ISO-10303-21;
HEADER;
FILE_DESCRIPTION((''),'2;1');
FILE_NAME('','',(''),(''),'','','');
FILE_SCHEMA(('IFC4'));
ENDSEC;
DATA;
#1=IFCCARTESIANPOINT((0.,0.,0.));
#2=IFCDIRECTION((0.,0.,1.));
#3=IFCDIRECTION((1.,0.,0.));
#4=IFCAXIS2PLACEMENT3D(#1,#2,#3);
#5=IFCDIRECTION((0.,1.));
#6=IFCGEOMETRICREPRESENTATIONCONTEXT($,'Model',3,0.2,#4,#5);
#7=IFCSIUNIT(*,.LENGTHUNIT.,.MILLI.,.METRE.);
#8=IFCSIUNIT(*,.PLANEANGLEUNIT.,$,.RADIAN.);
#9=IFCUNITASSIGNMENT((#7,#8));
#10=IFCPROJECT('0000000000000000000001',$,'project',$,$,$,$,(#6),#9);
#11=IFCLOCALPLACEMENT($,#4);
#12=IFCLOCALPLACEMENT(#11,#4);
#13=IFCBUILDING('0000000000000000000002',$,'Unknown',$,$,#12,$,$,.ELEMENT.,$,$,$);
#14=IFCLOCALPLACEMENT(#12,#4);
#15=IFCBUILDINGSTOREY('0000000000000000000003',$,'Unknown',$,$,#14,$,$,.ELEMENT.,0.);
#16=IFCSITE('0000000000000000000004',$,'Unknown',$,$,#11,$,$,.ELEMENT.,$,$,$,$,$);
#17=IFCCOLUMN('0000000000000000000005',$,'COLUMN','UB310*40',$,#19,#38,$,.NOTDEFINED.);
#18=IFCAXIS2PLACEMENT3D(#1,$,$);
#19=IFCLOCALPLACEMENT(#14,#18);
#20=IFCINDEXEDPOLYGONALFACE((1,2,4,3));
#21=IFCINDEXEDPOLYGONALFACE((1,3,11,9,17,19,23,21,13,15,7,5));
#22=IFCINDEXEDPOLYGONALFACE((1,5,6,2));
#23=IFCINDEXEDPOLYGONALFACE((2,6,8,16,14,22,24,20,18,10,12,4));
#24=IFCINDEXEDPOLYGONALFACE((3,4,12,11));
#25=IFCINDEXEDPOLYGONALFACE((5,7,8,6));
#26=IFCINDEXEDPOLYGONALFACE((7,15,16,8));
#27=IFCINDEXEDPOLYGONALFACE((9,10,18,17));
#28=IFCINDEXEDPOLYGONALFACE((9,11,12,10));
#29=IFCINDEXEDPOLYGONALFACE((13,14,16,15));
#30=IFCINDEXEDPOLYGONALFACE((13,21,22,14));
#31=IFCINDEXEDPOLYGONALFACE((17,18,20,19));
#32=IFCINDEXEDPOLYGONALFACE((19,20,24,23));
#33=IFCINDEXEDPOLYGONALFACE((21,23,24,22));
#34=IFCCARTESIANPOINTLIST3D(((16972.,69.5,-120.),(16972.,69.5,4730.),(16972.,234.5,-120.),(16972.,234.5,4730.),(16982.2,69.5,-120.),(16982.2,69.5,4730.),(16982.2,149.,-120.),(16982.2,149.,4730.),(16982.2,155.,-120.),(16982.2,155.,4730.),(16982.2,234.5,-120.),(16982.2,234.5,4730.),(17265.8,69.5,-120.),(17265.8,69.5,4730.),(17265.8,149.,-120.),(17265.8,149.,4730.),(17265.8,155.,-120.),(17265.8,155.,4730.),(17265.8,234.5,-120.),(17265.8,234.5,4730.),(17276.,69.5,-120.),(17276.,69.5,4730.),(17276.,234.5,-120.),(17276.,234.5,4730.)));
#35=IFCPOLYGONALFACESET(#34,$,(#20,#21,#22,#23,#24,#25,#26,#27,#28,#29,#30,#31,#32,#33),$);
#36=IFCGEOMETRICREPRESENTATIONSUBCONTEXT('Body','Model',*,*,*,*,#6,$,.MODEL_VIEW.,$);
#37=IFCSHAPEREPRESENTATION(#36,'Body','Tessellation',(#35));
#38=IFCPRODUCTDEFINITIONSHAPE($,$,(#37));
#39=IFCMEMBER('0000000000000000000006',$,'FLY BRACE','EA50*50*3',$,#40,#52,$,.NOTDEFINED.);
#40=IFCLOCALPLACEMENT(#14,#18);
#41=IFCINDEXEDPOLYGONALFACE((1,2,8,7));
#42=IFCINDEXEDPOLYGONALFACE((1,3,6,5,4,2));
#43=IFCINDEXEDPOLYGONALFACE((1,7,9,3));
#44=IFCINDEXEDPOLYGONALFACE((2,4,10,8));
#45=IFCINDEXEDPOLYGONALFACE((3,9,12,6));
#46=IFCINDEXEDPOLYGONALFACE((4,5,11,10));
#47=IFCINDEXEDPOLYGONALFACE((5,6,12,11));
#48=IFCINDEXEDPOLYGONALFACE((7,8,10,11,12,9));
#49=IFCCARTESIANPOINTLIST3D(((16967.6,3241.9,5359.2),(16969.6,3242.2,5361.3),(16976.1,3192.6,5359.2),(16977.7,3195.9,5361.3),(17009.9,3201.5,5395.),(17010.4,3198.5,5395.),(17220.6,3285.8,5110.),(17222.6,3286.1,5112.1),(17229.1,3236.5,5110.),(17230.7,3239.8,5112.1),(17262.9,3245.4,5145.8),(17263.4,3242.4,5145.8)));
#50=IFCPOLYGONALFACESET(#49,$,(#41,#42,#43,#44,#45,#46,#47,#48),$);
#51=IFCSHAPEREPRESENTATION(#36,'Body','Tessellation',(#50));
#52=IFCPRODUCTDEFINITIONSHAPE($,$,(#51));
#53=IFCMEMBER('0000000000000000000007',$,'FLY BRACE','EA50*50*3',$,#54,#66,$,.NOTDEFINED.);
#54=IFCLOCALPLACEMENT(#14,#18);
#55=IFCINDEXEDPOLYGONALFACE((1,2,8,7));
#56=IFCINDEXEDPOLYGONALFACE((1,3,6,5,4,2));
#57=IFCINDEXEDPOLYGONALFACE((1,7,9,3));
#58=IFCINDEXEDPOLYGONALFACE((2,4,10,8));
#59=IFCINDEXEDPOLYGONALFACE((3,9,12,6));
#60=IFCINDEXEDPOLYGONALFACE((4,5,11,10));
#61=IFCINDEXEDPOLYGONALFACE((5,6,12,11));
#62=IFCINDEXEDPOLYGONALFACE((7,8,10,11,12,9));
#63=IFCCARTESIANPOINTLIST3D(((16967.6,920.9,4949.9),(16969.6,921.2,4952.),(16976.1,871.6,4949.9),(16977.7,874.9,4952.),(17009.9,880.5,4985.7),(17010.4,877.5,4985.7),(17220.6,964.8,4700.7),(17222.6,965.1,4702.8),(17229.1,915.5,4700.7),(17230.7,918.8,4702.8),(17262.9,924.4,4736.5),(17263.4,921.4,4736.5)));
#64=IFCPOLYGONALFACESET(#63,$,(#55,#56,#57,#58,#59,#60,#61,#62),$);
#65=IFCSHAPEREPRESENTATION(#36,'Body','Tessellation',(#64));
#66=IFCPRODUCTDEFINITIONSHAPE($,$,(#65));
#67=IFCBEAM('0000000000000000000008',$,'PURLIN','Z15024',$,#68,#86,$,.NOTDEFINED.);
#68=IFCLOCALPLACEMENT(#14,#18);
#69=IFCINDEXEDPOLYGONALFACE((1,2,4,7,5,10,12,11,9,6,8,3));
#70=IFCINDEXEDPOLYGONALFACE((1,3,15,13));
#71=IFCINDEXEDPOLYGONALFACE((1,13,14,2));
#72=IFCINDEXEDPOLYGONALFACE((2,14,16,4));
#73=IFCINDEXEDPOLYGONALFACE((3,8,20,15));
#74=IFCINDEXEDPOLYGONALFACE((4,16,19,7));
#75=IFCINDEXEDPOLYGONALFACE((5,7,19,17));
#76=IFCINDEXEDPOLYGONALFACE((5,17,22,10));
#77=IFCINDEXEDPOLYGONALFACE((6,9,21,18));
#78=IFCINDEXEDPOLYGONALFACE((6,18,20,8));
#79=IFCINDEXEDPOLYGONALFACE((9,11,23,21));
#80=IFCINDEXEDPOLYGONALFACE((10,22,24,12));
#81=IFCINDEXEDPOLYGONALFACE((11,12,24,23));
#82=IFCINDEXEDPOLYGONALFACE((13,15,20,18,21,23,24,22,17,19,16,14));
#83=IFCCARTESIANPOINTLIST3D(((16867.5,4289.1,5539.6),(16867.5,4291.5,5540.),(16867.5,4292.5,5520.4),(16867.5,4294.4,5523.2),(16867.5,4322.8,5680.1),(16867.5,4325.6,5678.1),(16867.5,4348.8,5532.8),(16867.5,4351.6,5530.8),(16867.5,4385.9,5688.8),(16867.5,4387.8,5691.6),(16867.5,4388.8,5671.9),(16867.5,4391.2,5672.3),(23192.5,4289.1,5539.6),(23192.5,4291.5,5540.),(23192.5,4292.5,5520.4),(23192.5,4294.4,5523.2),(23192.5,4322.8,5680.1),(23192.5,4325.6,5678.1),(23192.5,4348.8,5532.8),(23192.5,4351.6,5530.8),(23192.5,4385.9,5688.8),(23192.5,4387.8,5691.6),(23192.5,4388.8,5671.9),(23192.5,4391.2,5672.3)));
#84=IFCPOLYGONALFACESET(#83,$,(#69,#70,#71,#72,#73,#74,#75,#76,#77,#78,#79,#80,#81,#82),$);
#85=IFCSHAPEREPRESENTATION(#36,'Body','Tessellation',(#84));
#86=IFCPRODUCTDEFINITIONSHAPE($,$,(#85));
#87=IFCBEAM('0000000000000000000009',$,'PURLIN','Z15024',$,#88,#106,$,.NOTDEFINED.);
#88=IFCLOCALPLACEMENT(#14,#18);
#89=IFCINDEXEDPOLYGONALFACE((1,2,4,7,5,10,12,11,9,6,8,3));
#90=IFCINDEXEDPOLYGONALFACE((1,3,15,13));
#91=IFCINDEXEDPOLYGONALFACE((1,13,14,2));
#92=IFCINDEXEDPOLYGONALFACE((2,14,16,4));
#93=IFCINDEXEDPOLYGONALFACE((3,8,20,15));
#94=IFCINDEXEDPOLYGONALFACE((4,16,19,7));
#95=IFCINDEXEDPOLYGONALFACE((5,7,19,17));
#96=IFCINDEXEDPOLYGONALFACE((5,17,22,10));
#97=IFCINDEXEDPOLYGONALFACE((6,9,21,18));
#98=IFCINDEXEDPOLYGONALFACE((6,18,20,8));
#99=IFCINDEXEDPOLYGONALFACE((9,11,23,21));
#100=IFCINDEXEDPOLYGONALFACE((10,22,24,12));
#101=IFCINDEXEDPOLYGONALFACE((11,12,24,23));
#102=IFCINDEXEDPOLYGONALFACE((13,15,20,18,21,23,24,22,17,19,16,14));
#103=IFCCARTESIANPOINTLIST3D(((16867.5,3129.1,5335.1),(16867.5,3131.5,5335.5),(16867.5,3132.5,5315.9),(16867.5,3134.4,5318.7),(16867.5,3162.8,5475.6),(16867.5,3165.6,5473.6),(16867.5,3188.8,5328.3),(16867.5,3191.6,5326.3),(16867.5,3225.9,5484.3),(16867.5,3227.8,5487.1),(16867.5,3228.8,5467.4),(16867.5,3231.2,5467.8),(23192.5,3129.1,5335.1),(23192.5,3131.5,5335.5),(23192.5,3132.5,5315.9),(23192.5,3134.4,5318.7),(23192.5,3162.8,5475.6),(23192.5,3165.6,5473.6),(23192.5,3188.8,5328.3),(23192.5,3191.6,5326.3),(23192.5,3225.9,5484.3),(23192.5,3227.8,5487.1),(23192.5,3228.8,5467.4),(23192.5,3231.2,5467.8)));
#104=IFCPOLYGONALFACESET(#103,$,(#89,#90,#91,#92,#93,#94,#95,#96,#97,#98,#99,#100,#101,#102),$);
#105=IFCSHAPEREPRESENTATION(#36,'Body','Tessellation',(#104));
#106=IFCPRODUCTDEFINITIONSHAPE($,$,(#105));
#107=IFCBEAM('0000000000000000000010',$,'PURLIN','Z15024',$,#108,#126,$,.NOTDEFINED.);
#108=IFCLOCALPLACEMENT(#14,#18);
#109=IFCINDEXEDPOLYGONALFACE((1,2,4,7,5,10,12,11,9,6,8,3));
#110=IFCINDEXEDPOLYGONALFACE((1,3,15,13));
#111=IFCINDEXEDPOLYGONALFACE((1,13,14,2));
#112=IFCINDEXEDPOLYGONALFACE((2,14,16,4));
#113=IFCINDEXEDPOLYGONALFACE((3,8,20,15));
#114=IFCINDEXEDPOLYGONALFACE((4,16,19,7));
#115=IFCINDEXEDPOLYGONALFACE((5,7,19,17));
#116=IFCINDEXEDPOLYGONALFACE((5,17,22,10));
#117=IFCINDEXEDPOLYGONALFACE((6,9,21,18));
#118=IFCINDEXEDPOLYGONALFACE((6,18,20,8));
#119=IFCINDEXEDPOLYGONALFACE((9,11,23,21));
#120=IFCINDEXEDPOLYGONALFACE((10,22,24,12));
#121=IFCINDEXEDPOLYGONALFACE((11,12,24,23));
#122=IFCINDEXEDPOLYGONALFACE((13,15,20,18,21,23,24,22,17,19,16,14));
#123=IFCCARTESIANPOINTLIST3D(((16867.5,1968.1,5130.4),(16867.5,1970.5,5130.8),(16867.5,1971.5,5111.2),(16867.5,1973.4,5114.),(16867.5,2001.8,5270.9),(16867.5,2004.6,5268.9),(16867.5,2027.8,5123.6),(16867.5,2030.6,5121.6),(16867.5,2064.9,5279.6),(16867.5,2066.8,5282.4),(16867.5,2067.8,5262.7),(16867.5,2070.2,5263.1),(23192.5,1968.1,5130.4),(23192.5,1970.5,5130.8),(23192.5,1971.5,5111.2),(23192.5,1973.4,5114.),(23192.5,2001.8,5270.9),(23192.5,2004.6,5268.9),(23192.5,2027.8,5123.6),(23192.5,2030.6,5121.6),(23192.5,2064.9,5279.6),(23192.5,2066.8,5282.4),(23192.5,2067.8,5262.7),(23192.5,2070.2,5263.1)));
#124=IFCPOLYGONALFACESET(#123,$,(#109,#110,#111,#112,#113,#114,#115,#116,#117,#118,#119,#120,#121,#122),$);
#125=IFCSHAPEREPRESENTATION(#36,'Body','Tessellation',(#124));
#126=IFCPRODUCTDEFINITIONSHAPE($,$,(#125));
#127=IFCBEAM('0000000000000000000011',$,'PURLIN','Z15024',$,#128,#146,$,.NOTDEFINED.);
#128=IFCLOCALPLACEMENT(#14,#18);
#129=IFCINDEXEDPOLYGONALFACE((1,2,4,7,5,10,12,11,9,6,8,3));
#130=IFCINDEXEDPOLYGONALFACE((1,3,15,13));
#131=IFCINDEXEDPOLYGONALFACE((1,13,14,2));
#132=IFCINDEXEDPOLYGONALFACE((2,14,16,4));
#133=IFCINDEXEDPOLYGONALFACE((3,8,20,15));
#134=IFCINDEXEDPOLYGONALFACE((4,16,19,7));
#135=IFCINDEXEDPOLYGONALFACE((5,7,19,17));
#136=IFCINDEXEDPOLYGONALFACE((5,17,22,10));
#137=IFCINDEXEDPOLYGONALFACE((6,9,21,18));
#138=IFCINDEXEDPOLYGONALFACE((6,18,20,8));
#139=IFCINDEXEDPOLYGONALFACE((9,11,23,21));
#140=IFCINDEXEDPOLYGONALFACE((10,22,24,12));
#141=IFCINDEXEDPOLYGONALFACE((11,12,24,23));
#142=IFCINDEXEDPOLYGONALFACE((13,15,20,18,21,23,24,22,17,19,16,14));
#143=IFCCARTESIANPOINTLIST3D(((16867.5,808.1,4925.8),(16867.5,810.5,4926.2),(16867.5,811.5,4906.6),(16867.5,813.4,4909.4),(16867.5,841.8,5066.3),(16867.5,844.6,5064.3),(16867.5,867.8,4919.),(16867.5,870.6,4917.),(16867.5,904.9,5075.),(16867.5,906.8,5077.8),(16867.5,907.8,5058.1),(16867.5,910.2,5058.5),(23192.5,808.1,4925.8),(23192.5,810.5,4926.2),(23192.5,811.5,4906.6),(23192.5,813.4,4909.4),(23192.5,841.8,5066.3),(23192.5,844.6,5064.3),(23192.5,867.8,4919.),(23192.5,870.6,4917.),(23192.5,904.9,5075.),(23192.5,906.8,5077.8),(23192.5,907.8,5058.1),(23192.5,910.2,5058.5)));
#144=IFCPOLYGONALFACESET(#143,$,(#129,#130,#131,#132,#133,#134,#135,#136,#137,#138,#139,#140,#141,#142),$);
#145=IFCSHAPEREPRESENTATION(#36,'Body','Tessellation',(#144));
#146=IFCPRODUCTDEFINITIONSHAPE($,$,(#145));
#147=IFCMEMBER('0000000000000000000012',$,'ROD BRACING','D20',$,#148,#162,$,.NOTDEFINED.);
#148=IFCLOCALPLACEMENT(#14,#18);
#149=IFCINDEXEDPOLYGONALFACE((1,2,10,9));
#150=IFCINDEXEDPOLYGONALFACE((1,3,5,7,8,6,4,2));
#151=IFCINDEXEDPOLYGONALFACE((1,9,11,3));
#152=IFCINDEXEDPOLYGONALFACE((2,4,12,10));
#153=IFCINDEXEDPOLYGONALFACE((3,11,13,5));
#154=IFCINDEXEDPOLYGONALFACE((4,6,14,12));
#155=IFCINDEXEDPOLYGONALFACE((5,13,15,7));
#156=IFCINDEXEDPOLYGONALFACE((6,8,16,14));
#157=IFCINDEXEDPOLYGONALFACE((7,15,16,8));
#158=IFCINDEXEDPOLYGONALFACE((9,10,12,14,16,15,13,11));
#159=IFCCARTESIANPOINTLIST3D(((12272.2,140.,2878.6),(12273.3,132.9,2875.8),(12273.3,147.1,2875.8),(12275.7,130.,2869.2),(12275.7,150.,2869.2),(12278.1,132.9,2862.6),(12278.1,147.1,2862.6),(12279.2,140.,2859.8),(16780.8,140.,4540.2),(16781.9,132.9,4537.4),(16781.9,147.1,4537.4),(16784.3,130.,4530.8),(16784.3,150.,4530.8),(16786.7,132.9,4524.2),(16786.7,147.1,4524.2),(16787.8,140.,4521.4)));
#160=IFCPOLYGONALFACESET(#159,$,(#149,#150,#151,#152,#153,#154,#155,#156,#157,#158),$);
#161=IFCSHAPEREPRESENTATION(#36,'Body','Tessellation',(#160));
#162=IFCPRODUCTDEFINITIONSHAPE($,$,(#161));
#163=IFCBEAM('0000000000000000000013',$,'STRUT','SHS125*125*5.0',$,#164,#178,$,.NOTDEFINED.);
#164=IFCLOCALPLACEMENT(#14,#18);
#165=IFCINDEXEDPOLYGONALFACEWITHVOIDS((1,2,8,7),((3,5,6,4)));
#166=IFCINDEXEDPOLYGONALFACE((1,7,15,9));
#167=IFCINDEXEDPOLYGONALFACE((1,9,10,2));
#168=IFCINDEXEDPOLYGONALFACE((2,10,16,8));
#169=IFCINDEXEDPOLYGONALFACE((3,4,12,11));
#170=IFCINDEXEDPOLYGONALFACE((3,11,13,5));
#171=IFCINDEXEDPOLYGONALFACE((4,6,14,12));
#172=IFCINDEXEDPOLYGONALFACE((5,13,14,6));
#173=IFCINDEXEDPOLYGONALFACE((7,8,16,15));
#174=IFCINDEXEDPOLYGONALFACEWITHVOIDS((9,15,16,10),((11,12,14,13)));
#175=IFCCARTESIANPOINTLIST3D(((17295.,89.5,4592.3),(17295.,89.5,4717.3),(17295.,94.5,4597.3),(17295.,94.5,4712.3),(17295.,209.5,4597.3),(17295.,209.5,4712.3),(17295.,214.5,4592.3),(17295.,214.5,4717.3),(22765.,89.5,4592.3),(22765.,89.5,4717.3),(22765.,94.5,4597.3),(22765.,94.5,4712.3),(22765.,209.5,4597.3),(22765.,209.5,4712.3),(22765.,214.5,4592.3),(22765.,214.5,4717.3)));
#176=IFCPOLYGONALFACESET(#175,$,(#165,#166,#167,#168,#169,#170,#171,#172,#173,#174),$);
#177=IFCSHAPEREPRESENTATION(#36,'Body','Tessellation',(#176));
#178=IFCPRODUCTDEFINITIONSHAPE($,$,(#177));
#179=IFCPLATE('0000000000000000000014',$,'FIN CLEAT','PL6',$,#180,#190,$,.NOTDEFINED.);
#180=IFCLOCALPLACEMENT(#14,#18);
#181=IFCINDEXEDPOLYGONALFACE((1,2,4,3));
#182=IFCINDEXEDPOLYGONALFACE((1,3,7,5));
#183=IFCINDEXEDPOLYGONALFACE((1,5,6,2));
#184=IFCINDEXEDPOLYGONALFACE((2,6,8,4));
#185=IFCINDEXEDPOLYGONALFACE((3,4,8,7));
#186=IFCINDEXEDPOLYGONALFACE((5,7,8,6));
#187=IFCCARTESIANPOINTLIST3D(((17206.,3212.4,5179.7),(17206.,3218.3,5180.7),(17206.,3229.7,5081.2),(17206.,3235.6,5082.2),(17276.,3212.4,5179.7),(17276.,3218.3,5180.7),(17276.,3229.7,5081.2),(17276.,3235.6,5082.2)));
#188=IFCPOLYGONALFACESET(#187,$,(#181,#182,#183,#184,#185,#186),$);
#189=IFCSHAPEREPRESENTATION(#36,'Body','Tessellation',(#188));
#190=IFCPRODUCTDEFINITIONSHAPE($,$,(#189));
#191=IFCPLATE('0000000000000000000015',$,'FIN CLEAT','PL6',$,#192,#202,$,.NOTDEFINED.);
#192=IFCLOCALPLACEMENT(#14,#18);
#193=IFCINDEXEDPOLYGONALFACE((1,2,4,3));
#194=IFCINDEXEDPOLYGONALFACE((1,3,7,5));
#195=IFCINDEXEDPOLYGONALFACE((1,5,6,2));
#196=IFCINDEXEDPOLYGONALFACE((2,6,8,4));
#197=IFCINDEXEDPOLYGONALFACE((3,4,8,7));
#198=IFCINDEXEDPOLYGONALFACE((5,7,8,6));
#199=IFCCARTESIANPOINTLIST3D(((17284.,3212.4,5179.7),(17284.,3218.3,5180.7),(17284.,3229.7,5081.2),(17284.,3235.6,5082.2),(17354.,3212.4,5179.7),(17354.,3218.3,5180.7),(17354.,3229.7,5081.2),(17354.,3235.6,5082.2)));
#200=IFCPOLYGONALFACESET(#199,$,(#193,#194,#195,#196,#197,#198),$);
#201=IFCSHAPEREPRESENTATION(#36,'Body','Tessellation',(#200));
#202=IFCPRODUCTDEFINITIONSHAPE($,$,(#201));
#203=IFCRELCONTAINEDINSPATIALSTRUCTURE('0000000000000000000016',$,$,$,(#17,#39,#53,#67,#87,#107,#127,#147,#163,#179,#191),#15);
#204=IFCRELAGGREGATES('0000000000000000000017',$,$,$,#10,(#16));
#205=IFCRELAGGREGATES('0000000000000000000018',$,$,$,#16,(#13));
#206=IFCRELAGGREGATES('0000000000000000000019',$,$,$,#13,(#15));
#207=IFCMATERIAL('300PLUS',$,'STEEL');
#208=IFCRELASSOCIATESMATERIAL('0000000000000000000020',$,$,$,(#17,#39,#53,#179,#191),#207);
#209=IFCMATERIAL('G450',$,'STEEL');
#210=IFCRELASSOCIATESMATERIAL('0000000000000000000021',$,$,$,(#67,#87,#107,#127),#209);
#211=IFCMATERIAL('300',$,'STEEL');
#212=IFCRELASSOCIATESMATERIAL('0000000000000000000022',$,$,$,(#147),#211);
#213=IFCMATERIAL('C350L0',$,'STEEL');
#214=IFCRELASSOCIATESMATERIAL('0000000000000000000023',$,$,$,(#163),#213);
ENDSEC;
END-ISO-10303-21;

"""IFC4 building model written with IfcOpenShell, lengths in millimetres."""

from ifc_helpers import new_model, si_unit, direction, frame, origin_with_axes, place, context, subcontext, project, spatial, line, indexed_curve, outline, extrude, material, element, save


model = new_model("IFC4")

# Units and contexts
model_context = context("Model", 3, precision=0.2, world=origin_with_axes(), true_north=direction((0.0, 1.0)))
body_context = subcontext(model_context, "Body", "Model", "MODEL_VIEW")
ifc_project = project(units=[si_unit("LENGTHUNIT", "METRE", prefix="MILLI"), si_unit("PLANEANGLEUNIT", "RADIAN")], contexts=[model_context])

# Site, building, storey
site_placement = place(None, origin_with_axes())
site = spatial("IfcSite", under=ifc_project, at=site_placement, Name="Unknown", CompositionType="ELEMENT")
building_placement = place(site_placement, origin_with_axes())
building = spatial("IfcBuilding", under=site, at=building_placement, Name="Unknown", CompositionType="ELEMENT")
storey_placement = place(building_placement, origin_with_axes())
storey = spatial("IfcBuildingStorey", under=building, at=storey_placement, Name="Unknown", CompositionType="ELEMENT", Elevation=0.0)

# Column
ifc_material_1 = material(Name="300PLUS", Category="STEEL")
column_placement = place(storey_placement, frame((17124.0, 152.0, -120.0), z_axis=(0.0, -1.0, 0.0), x_axis=(0.0, 0.0, 1.0)))
element("IfcColumn", 1, at=column_placement, inside=storey, material=ifc_material_1, Name="COLUMN", Description="UB310*40", PredefinedType="NOTDEFINED", context=body_context, shape_type="SolidModel", body=[
    extrude(outline(indexed_curve([(-82.5, -152.0), (82.5, -152.0), (82.5, -141.8), (3.0, -141.8), (3.0, 141.8), (82.5, 141.8), (82.5, 152.0), (-82.5, 152.0), (-82.5, 141.8), (-3.0, 141.8), (-3.0, -141.8), (-82.5, -141.8)], segments=[line(1, 2, 3, 4, 5, 6, 7, 8, 9, 10, 11, 12, 1)])), frame((0.0, 0.0, 0.0), z_axis=(-1.0, 0.0, 0.0), x_axis=(0.0, 0.0, 1.0)), (0.0, 0.0, -1.0), 4850.0),
])

# Members
for number, where, z_axis, x_axis, name in (
    (2, (16989.0, 3220.2, 5377.1), (0.686182, 0.119065, 0.71762), (0.707055, 0.122687, -0.696435), "FLY BRACE"),
    (3, (16989.0, 899.2, 4967.8), (0.686182, 0.119065, 0.71762), (0.707055, 0.122687, -0.696435), "FLY BRACE"),
):
    element("IfcMember", number, at=place(storey_placement, frame(where, z_axis=z_axis, x_axis=x_axis)), inside=storey, material=ifc_material_1, Name=name, Description="EA50*50*3", PredefinedType="NOTDEFINED", context=body_context, shape_type="SolidModel", body=[
        extrude(outline(indexed_curve([(-25.0, -25.0), (25.0, -25.0), (25.0, -22.0), (-22.0, -22.0), (-22.0, 25.0), (-25.0, 25.0)], segments=[line(1, 2, 3, 4, 5, 6, 1)])), frame((0.0, 0.0, 0.0), z_axis=(-1.0, 0.0, 0.0), x_axis=(0.0, 0.0, 1.0)), (0.0, 0.0, -1.0), 357.8),
    ])

# Beams
ifc_material_2 = material(Name="G450", Category="STEEL")
for number, where, z_axis, x_axis, name in (
    (4, (16867.5, 4337.2, 5605.5), (0.0, -0.984808, -0.173648), (1.0, 0.0, 0.0), "PURLIN"),
    (5, (16867.5, 3177.2, 5401.0), (0.0, -0.984808, -0.173648), (1.0, 0.0, 0.0), "PURLIN"),
    (6, (16867.5, 2016.2, 5196.3), (0.0, -0.984808, -0.173648), (1.0, 0.0, 0.0), "PURLIN"),
    (7, (16867.5, 856.2, 4991.7), (0.0, -0.984808, -0.173648), (1.0, 0.0, 0.0), "PURLIN"),
):
    element("IfcBeam", number, at=place(storey_placement, frame(where, z_axis=z_axis, x_axis=x_axis)), inside=storey, material=ifc_material_2, Name=name, Description="Z15024", PredefinedType="NOTDEFINED", context=body_context, shape_type="SolidModel", body=[
        extrude(outline(indexed_curve([(58.8, -76.0), (58.8, -56.5), (56.4, -56.5), (56.4, -73.6), (1.2, -73.6), (1.2, 76.0), (-64.8, 76.0), (-64.8, 56.5), (-62.4, 56.5), (-62.4, 73.6), (-1.2, 73.6), (-1.2, -76.0)], segments=[line(1, 2, 3, 4, 5, 6, 7, 8, 9, 10, 11, 12, 1)])), frame((0.0, 0.0, 0.0), z_axis=(-1.0, 0.0, 0.0), x_axis=(0.0, 0.0, 1.0)), (0.0, 0.0, -1.0), 6325.0),
    ])

# Member
ifc_material_3 = material(Name="300", Category="STEEL")
member_placement = place(storey_placement, frame((16784.3, 140.0, 4530.8), z_axis=(-0.345804, 0.0, 0.938307), x_axis=(-0.938307, 0.0, -0.345804)))
element("IfcMember", 8, at=member_placement, inside=storey, material=ifc_material_3, Name="ROD BRACING", Description="D20", PredefinedType="NOTDEFINED", context=body_context, shape_type="SolidModel", body=[
    extrude(outline(indexed_curve([(10.0, 0.0), (7.1, 7.1), (0.0, 10.0), (-7.1, 7.1), (-10.0, 0.0), (-7.1, -7.1), (0.0, -10.0), (7.1, -7.1)], segments=[line(1, 2, 3, 4, 5, 6, 7, 8, 1)])), frame((0.0, 0.0, 0.0), z_axis=(-1.0, 0.0, 0.0), x_axis=(0.0, 0.0, 1.0)), (0.0, 0.0, -1.0), 4805.0),
])

# Beam
ifc_material_4 = material(Name="C350L0", Category="STEEL")
beam_placement = place(storey_placement, frame((17295.0, 152.0, 4654.8), z_axis=(0.0, 0.0, 1.0), x_axis=(1.0, 0.0, 0.0)))
element("IfcBeam", 9, at=beam_placement, inside=storey, material=ifc_material_4, Name="STRUT", Description="SHS125*125*5.0", PredefinedType="NOTDEFINED", context=body_context, shape_type="SolidModel", body=[
    extrude(outline(indexed_curve([(-62.5, -62.5), (62.5, -62.5), (62.5, 62.5), (-62.5, 62.5)], segments=[line(1, 2, 3, 4, 1)]), holes=[indexed_curve([(-57.5, -57.5), (-57.5, 57.5), (57.5, 57.5), (57.5, -57.5)], segments=[line(1, 2, 3, 4, 1)])]), frame((0.0, 0.0, 0.0), z_axis=(-1.0, 0.0, 0.0), x_axis=(0.0, 0.0, 1.0)), (0.0, 0.0, -1.0), 5470.0),
])

# Plates
for number, where, z_axis, x_axis, name in (
    (10, (17206.0, 3215.4, 5180.2), (0.0, 0.984924, 0.172987), (1.0, 0.0, 0.0), "FIN CLEAT"),
    (11, (17284.0, 3215.4, 5180.2), (0.0, 0.984924, 0.172987), (1.0, 0.0, 0.0), "FIN CLEAT"),
):
    element("IfcPlate", number, at=place(storey_placement, frame(where, z_axis=z_axis, x_axis=x_axis)), inside=storey, material=ifc_material_1, Name=name, Description="PL6", PredefinedType="NOTDEFINED", context=body_context, shape_type="SolidModel", body=[
        extrude(outline(indexed_curve([(0.0, 0.0), (70.0, 0.0), (70.0, 100.0), (0.0, 100.0)], segments=[line(1, 2, 3, 4, 1)])), frame((0.0, 0.0, 3.0), z_axis=(0.0, 0.0, 1.0), x_axis=(1.0, 0.0, 0.0)), (0.0, 0.0, -1.0), 6.0),
    ])

save(model, "model.ifc")
